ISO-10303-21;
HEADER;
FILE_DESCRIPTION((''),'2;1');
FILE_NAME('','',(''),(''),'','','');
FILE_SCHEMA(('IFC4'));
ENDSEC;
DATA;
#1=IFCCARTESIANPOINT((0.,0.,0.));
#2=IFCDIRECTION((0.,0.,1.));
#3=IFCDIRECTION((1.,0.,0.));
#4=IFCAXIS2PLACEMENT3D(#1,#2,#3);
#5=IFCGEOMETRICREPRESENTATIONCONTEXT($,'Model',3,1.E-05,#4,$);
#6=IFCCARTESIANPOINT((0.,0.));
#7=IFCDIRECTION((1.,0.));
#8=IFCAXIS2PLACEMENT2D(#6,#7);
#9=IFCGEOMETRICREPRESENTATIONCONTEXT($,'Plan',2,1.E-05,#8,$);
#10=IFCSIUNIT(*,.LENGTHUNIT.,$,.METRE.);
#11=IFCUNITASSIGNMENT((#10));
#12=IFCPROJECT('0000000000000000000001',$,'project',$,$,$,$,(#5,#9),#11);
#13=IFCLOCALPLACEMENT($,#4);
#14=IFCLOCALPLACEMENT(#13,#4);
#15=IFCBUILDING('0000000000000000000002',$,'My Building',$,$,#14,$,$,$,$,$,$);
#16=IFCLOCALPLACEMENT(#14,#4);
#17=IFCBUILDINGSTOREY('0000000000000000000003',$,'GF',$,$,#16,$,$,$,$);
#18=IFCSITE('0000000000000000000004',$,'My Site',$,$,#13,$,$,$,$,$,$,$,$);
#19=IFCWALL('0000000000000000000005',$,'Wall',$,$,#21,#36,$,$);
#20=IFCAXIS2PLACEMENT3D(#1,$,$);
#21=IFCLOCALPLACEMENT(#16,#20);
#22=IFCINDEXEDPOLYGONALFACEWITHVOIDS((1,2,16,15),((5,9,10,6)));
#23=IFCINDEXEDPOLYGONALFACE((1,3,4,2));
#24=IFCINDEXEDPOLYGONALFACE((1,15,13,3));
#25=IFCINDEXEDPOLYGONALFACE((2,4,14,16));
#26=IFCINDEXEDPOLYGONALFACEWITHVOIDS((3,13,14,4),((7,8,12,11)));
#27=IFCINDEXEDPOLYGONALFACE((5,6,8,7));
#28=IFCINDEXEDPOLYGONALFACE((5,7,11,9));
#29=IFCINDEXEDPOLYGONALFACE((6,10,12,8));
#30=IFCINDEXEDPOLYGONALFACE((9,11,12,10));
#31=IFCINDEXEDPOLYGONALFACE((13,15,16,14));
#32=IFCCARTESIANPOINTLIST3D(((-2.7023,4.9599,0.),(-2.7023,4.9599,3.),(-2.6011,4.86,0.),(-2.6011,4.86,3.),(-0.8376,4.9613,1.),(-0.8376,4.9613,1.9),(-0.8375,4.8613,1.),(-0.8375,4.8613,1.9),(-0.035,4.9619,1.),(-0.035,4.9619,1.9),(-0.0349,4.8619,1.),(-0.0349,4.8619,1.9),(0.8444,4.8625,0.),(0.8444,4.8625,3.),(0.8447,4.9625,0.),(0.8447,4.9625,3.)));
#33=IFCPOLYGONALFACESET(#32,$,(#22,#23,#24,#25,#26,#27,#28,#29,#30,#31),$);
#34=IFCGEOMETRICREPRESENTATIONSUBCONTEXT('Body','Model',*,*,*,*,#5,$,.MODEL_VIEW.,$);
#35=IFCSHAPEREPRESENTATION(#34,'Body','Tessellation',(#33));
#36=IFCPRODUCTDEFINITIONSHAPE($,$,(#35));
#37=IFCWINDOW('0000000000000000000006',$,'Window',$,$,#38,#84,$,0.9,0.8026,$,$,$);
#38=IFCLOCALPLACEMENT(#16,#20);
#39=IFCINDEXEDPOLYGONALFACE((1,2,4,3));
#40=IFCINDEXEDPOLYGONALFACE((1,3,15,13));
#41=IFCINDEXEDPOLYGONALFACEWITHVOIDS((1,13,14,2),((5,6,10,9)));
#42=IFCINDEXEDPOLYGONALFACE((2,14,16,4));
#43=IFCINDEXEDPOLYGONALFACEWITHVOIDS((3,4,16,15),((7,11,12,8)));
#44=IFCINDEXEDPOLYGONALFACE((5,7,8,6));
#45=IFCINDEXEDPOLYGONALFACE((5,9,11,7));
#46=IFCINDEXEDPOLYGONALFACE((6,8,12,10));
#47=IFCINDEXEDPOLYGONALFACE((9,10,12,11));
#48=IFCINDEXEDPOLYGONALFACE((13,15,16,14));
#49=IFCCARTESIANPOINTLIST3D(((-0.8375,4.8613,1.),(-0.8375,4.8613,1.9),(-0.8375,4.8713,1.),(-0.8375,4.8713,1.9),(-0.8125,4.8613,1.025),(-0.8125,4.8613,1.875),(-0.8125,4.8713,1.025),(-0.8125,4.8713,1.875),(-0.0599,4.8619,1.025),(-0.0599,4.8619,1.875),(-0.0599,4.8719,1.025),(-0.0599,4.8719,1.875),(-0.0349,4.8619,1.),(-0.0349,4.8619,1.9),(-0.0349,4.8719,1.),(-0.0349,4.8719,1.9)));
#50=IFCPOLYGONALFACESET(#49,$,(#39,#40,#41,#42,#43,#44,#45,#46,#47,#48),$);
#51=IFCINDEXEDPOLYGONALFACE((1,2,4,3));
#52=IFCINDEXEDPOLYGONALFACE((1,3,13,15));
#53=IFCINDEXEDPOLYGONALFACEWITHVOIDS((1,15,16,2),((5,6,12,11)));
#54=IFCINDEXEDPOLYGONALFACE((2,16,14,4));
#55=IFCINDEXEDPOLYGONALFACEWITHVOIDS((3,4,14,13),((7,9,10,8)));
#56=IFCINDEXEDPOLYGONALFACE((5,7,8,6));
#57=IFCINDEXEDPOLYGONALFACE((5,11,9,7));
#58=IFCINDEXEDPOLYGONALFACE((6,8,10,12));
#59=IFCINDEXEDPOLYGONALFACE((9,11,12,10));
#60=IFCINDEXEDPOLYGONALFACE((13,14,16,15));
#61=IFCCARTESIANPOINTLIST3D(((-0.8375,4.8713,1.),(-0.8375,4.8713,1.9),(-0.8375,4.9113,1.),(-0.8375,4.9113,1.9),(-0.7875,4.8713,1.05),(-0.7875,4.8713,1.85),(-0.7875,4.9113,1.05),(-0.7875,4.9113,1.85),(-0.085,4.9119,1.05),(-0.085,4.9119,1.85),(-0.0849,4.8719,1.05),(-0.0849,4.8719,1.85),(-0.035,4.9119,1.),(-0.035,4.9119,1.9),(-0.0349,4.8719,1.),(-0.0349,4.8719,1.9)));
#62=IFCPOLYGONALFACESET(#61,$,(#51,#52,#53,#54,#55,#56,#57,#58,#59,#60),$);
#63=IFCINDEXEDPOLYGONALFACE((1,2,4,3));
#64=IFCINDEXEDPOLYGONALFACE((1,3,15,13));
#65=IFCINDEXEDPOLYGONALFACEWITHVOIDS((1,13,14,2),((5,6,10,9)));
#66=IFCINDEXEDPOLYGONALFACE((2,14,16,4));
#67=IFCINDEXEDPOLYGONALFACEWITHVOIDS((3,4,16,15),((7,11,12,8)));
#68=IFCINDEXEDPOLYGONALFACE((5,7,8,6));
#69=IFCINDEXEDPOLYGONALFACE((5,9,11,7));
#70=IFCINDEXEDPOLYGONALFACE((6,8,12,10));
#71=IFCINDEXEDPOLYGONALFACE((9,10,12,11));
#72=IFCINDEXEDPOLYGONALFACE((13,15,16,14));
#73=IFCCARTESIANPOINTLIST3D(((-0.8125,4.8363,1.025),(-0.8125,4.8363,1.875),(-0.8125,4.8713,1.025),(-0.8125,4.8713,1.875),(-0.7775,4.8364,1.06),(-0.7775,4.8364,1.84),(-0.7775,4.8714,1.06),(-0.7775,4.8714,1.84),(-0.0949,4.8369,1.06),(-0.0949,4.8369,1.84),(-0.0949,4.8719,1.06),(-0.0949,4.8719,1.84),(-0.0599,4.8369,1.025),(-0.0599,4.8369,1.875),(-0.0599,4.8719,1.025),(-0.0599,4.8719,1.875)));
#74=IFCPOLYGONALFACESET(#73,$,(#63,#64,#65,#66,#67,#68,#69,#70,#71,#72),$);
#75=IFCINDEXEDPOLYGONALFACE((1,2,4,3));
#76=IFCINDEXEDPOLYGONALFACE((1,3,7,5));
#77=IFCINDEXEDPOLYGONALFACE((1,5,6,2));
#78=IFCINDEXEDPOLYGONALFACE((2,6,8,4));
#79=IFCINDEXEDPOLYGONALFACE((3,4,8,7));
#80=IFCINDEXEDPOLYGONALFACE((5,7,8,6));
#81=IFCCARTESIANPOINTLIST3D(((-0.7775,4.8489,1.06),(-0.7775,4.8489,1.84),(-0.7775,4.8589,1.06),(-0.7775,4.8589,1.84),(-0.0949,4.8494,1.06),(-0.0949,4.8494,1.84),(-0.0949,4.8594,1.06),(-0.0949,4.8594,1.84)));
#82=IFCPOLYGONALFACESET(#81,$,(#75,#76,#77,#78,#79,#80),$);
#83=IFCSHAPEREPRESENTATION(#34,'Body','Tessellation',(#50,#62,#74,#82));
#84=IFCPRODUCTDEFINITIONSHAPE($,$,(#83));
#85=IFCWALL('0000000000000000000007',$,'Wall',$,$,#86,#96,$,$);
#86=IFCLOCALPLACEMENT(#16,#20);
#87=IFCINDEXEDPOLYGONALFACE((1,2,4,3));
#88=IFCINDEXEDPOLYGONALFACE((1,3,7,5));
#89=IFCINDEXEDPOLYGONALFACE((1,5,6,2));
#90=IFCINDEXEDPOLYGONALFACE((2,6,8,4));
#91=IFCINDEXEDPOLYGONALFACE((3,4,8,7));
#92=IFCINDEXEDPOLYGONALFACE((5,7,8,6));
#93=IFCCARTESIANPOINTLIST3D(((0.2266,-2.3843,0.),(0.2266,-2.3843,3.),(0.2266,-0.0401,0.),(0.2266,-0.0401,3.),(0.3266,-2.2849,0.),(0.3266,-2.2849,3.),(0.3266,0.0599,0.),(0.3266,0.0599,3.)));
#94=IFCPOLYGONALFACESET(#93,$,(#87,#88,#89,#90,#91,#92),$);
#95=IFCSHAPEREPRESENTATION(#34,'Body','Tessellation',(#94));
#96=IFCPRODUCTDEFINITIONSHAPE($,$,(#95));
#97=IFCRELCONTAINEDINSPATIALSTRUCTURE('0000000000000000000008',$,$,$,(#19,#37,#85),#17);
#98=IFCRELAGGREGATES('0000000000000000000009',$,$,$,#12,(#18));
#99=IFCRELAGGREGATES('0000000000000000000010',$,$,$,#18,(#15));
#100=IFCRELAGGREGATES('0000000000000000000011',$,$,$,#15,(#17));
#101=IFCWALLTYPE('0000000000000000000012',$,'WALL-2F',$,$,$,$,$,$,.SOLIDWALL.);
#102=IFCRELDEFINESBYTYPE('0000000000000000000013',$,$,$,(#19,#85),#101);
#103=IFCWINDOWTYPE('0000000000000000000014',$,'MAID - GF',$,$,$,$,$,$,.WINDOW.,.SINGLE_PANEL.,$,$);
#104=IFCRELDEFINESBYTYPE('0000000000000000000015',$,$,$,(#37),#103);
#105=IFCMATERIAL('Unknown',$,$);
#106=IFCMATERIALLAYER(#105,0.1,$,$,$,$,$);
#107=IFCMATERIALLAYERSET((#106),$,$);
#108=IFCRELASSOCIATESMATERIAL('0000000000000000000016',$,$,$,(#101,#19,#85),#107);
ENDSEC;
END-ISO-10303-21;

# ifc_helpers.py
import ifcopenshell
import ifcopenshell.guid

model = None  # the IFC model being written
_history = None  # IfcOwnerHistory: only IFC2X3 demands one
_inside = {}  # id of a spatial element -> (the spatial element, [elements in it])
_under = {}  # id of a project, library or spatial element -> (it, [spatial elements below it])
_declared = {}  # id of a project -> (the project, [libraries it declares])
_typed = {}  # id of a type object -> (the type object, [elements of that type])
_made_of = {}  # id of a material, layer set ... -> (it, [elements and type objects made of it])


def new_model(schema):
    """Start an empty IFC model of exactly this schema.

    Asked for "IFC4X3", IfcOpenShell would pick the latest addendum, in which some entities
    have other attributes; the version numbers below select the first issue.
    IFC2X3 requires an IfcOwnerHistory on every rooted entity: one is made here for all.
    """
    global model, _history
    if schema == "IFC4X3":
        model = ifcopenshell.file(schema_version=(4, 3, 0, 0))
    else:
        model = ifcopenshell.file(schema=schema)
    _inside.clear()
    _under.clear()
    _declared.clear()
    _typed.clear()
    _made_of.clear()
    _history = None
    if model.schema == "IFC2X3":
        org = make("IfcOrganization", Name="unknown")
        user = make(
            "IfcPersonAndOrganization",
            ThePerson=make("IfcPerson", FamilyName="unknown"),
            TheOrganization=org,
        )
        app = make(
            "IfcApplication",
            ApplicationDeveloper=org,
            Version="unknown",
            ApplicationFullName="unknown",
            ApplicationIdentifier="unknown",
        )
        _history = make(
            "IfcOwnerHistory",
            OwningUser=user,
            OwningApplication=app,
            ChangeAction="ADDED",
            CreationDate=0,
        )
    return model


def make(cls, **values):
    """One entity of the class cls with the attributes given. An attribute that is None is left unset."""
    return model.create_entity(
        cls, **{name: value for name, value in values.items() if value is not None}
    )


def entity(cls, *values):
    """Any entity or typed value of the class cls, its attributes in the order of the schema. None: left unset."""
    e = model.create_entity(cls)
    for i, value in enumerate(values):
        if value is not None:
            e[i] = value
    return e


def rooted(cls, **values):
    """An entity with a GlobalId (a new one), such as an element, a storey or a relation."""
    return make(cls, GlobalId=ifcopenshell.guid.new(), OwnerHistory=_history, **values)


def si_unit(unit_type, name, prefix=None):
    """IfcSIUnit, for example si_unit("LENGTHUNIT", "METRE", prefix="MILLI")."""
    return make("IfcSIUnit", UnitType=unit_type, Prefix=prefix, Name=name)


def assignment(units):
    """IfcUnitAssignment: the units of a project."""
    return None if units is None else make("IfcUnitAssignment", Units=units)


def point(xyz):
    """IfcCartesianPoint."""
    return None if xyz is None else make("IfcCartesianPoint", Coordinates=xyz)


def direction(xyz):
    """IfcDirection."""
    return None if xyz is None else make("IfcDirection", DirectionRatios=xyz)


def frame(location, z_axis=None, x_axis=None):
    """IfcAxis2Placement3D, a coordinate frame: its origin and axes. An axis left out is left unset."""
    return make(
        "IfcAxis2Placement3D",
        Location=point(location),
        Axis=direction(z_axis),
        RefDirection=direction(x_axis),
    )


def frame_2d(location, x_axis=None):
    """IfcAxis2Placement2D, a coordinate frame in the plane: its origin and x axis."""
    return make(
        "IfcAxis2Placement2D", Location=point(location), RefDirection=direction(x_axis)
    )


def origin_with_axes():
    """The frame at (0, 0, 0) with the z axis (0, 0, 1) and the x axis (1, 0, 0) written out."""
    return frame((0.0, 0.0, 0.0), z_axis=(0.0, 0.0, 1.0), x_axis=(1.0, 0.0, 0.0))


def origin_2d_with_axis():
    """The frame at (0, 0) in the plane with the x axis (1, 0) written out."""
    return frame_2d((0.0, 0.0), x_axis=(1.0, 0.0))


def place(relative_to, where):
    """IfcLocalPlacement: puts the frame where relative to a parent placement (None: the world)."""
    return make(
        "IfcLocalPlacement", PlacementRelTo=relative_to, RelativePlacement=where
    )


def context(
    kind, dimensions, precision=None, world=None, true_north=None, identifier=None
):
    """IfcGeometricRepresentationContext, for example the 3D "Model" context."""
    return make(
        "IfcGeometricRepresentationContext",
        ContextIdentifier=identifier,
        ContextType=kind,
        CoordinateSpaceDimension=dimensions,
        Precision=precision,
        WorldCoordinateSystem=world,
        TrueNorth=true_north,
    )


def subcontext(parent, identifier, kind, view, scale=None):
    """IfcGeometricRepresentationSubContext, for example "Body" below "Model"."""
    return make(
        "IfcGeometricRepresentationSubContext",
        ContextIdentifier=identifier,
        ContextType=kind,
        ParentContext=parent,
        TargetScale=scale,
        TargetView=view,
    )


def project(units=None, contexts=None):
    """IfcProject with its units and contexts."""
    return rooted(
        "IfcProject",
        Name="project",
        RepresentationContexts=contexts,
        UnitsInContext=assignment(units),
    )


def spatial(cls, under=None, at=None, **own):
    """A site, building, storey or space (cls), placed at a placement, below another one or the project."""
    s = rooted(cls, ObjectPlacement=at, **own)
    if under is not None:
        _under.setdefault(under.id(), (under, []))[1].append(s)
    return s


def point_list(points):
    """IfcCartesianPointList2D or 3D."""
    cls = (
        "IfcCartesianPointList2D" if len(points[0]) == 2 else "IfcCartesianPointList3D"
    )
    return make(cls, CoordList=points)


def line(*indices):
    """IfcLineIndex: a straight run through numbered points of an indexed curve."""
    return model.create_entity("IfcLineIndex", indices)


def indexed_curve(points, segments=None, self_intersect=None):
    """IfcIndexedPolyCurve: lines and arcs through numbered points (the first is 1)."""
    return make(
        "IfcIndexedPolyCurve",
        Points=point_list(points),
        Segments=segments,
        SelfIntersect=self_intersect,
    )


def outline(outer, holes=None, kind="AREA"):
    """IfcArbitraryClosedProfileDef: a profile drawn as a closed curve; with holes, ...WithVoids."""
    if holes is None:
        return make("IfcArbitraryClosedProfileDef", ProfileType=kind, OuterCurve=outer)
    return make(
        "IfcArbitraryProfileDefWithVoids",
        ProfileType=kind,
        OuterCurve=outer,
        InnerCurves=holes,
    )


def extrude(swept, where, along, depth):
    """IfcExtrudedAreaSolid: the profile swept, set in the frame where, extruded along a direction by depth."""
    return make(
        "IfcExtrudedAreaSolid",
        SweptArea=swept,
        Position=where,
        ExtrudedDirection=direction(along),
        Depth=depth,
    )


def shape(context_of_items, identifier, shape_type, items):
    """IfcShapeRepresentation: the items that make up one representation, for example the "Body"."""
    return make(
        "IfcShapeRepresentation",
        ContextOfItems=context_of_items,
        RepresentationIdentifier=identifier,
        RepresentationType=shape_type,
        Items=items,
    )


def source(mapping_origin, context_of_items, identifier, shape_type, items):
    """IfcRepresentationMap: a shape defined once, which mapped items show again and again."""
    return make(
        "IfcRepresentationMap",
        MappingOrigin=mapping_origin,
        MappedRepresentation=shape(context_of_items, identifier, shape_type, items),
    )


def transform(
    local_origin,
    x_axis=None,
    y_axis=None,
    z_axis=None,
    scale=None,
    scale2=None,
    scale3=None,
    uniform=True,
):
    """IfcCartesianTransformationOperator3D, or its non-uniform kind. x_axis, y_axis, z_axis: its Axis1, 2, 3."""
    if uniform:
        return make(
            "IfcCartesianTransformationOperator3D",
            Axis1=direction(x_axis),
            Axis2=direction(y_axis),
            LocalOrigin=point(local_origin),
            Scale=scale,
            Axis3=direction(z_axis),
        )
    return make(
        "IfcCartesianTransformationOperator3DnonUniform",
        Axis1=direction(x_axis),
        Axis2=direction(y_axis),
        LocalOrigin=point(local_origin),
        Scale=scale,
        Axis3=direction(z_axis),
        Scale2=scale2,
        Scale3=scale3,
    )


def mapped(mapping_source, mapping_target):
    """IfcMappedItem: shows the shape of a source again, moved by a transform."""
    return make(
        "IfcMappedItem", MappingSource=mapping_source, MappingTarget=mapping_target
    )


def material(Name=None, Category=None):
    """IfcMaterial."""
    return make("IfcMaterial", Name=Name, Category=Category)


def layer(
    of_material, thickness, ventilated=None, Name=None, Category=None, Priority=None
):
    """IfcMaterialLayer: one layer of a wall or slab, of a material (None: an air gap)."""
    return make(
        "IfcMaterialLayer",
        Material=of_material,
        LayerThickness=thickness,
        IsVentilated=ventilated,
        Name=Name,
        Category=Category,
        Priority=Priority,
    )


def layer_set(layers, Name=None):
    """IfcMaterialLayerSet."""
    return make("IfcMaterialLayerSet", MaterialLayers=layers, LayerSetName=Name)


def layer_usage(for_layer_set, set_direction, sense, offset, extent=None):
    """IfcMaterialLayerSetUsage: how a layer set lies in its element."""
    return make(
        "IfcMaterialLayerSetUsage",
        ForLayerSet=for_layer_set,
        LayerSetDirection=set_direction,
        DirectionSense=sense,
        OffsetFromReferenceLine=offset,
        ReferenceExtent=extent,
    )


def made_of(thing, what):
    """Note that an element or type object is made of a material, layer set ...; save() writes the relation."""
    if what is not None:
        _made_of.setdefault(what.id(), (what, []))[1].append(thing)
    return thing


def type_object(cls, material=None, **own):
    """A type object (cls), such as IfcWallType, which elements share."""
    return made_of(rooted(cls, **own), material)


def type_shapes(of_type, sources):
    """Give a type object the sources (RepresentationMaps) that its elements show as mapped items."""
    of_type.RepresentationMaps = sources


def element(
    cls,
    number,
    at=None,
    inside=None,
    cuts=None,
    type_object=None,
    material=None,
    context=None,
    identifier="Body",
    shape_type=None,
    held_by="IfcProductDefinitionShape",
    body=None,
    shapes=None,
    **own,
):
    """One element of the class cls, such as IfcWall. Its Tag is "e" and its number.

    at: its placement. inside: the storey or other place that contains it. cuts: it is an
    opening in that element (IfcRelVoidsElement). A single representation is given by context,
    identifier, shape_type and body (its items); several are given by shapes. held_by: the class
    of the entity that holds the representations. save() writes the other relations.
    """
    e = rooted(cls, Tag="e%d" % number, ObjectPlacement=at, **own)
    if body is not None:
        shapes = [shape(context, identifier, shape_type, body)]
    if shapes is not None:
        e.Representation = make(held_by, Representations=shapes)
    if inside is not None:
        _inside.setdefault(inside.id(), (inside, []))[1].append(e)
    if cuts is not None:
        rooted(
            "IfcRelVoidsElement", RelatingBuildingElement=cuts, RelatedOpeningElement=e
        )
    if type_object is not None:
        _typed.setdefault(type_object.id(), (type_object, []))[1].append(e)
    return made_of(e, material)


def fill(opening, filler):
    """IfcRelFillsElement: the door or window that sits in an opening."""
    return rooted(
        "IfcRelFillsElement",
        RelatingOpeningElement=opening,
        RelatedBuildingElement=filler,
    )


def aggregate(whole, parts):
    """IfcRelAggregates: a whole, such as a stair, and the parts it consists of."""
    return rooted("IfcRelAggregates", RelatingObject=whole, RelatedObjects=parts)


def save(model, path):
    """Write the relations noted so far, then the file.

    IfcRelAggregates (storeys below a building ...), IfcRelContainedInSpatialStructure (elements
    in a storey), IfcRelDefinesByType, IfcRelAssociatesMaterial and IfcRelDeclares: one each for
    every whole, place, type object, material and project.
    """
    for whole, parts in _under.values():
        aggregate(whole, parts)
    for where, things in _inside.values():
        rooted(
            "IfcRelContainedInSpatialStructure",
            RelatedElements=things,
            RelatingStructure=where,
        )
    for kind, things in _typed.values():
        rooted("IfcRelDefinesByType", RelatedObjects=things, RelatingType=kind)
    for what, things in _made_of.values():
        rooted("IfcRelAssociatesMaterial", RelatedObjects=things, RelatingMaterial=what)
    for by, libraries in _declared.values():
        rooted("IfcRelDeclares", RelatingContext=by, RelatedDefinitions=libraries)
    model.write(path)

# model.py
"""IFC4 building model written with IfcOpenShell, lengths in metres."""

from ifc_helpers import new_model, entity, si_unit, frame, origin_with_axes, origin_2d_with_axis, place, context, subcontext, project, spatial, line, indexed_curve, outline, extrude, shape, source, transform, mapped, material, layer, layer_set, layer_usage, type_object, type_shapes, element, fill, save


model = new_model("IFC4")

# Units and contexts
model_context = context("Model", 3, precision=1e-05, world=origin_with_axes())
plan_context = context("Plan", 2, precision=1e-05, world=origin_2d_with_axis())
body_context_1 = subcontext(model_context, "Body", "Model", "MODEL_VIEW")
body_context_2 = subcontext(plan_context, "Body", "Plan", "PLAN_VIEW")
ifc_project = project(units=[si_unit("LENGTHUNIT", "METRE")], contexts=[model_context, plan_context])

# Site, building, storey
site_placement = place(None, origin_with_axes())
site = spatial("IfcSite", under=ifc_project, at=site_placement, Name="My Site")
building_placement = place(site_placement, origin_with_axes())
building = spatial("IfcBuilding", under=site, at=building_placement, Name="My Building")
storey_placement = place(building_placement, origin_with_axes())
storey = spatial("IfcBuildingStorey", under=building, at=storey_placement, Name="GF")

# Shared definitions
ifc_material = material(Name="Unknown")

# Shared definitions
ifc_layer_1 = layer(ifc_material, 0.1)
ifc_layer_set_1 = layer_set([ifc_layer_1])
wall_type = type_object("IfcWallType", Name="WALL-2F", PredefinedType="SOLIDWALL", material=ifc_layer_set_1)

# Wall, opening, window
ifc_layer_usage_1 = layer_usage(ifc_layer_set_1, "AXIS2", "POSITIVE", 0.0)
wall_1_placement = place(storey_placement, frame((-2.7011, 4.8599, 0.0), z_axis=(0.0, 0.0, 1.0), x_axis=(1.0, 0.000731, 0.0)))
wall_1 = element("IfcWall", 1, at=wall_1_placement, inside=storey, type_object=wall_type, material=ifc_layer_usage_1, Name="Wall", context=body_context_1, shape_type="SweptSolid", body=[
    extrude(outline(indexed_curve([(0.1, 0.0), (-0.0011, 0.1), (3.5458, 0.1), (3.5455, 0.0)], segments=[line(1, 2, 3, 4, 1)])), origin_with_axes(), (0.0, 0.0, 1.0), 3.0),
])
shared_shape_1 = source(origin_with_axes(), body_context_1, "Body", "SweptSolid", [
    extrude(outline(indexed_curve([(0.0, 0.0), (0.8026, 0.0), (0.8026, 0.9), (0.0, 0.9)], segments=[line(1, 2, 3, 4, 1)])), frame((0.0, -0.6, 0.0), z_axis=(0.0, -1.0, 0.0), x_axis=(1.0, 0.0, 0.0)), (0.0, 0.0, -1.0), 1.2),
])
opening_1_placement = place(wall_1_placement, frame((2.6662, 0.1, 1.0), z_axis=(0.0, 0.0, 1.0), x_axis=(-1.0, 0.0, 0.0)))
opening_1 = element("IfcOpeningElement", 2, at=opening_1_placement, cuts=wall_1, PredefinedType="OPENING", context=body_context_1, shape_type="MappedRepresentation", body=[
    mapped(shared_shape_1, transform((0.0, 0.0, 0.0), x_axis=(1.0, 0.0, 0.0), y_axis=(0.0, 1.0, 0.0), z_axis=(0.0, 0.0, 1.0), scale=1.0)),
])
window_type_1 = type_object("IfcWindowType", Name="MAID - GF", PartitioningType="SINGLE_PANEL", PredefinedType="WINDOW")
shared_shape_2 = source(origin_with_axes(), body_context_1, "Body", "SweptSolid", [
    extrude(outline(indexed_curve([(0.0, 0.0), (0.8026, 0.0), (0.8026, 0.9), (0.0, 0.9)], segments=[line(1, 2, 3, 4, 1)]), holes=[indexed_curve([(0.025, 0.025), (0.7776, 0.025), (0.7776, 0.875), (0.025, 0.875)], segments=[line(1, 2, 3, 4, 1)])]), frame((0.0, 0.09, 0.0), z_axis=(0.0, -1.0, 0.0), x_axis=(1.0, 0.0, 0.0)), (0.0, 0.0, -1.0), 0.01),
    extrude(outline(indexed_curve([(0.0, 0.0), (0.8026, 0.0), (0.8026, 0.9), (0.0, 0.9)], segments=[line(1, 2, 3, 4, 1)]), holes=[indexed_curve([(0.05, 0.05), (0.7526, 0.05), (0.7526, 0.85), (0.05, 0.85)], segments=[line(1, 2, 3, 4, 1)])]), frame((0.0, 0.05, 0.0), z_axis=(0.0, -1.0, 0.0), x_axis=(1.0, 0.0, 0.0)), (0.0, 0.0, -1.0), 0.04),
    extrude(outline(indexed_curve([(0.0, 0.0), (0.7526, 0.0), (0.7526, 0.85), (0.0, 0.85)], segments=[line(1, 2, 3, 4, 1)]), holes=[indexed_curve([(0.035, 0.035), (0.7176, 0.035), (0.7176, 0.815), (0.035, 0.815)], segments=[line(1, 2, 3, 4, 1)])]), frame((0.025, 0.09, 0.025), z_axis=(0.0, -1.0, 0.0), x_axis=(1.0, 0.0, 0.0)), (0.0, 0.0, -1.0), 0.035),
    extrude(outline(indexed_curve([(0.035, 0.035), (0.7176, 0.035), (0.7176, 0.815), (0.035, 0.815)], segments=[line(1, 2, 3, 4, 1)])), frame((0.025, 0.1025, 0.025), z_axis=(0.0, -1.0, 0.0), x_axis=(1.0, 0.0, 0.0)), (0.0, 0.0, -1.0), 0.01),
])
shared_shape_3 = source(origin_with_axes(), body_context_2, "Body", "Curve2D", [
    entity("IfcIndexedPolyCurve", entity("IfcCartesianPointList2D", [[0.05, 0.05], [0.7526, 0.05]])),
    entity("IfcIndexedPolyCurve", entity("IfcCartesianPointList2D", [[0.0, 0.1], [0.025, 0.1], [0.025, 0.09], [0.05, 0.09], [0.05, 0.05], [0.0, 0.05]]), [entity("IfcLineIndex", [1, 2, 3, 4, 5, 6, 1])]),
    entity("IfcIndexedPolyCurve", entity("IfcCartesianPointList2D", [[0.8026, 0.1], [0.7776, 0.1], [0.7776, 0.09], [0.7526, 0.09], [0.7526, 0.05], [0.8026, 0.05]]), [entity("IfcLineIndex", [1, 2, 3, 4, 5, 6, 1])]),
    entity("IfcIndexedPolyCurve", entity("IfcCartesianPointList2D", [[0.025, 0.09], [0.06, 0.09], [0.06, 0.125], [0.025, 0.125]]), [entity("IfcLineIndex", [1, 2, 3, 4, 1])]),
    entity("IfcIndexedPolyCurve", entity("IfcCartesianPointList2D", [[0.7776, 0.09], [0.7426, 0.09], [0.7426, 0.125], [0.7776, 0.125]]), [entity("IfcLineIndex", [1, 2, 3, 4, 1])]),
    entity("IfcIndexedPolyCurve", entity("IfcCartesianPointList2D", [[0.06, 0.09], [0.7426, 0.09]])),
    entity("IfcIndexedPolyCurve", entity("IfcCartesianPointList2D", [[0.06, 0.125], [0.7426, 0.125]])),
    entity("IfcIndexedPolyCurve", entity("IfcCartesianPointList2D", [[0.06, 0.1075], [0.7426, 0.1075]])),
])
type_shapes(window_type_1, [shared_shape_2, shared_shape_3])
window_1_placement = place(opening_1_placement, frame((0.0, 0.0, 0.0), z_axis=(0.0, 0.0, 1.0), x_axis=(1.0, 0.0, 0.0)))
window_1 = element("IfcWindow", 3, at=window_1_placement, inside=storey, type_object=window_type_1, Name="Window", OverallHeight=0.9, OverallWidth=0.8026, shapes=[
    shape(body_context_1, "Body", "MappedRepresentation", [mapped(shared_shape_2, transform((0.0, 0.0, 0.0), x_axis=(1.0, 0.0, 0.0), y_axis=(0.0, 1.0, 0.0), z_axis=(0.0, 0.0, 1.0), scale=1.0))]),
    shape(body_context_2, "Body", "MappedRepresentation", [mapped(shared_shape_3, transform((0.0, 0.0, 0.0), x_axis=(1.0, 0.0, 0.0), y_axis=(0.0, 1.0, 0.0), z_axis=(0.0, 0.0, 1.0), scale=1.0))]),
])
fill(opening_1, window_1)

# Wall
ifc_layer_usage_2 = layer_usage(ifc_layer_set_1, "AXIS2", "POSITIVE", 0.0)
wall_2_placement = place(storey_placement, frame((0.2266, -0.0401, 0.0), z_axis=(0.0, 0.0, 1.0), x_axis=(0.0, -1.0, 0.0)))
element("IfcWall", 4, at=wall_2_placement, inside=storey, type_object=wall_type, material=ifc_layer_usage_2, Name="Wall", context=body_context_1, shape_type="SweptSolid", body=[
    extrude(outline(indexed_curve([(0.0, 0.0), (-0.1, 0.1), (2.2448, 0.1), (2.3442, 0.0)], segments=[line(1, 2, 3, 4, 1)])), origin_with_axes(), (0.0, 0.0, 1.0), 3.0),
])

save(model, "model.ifc")
